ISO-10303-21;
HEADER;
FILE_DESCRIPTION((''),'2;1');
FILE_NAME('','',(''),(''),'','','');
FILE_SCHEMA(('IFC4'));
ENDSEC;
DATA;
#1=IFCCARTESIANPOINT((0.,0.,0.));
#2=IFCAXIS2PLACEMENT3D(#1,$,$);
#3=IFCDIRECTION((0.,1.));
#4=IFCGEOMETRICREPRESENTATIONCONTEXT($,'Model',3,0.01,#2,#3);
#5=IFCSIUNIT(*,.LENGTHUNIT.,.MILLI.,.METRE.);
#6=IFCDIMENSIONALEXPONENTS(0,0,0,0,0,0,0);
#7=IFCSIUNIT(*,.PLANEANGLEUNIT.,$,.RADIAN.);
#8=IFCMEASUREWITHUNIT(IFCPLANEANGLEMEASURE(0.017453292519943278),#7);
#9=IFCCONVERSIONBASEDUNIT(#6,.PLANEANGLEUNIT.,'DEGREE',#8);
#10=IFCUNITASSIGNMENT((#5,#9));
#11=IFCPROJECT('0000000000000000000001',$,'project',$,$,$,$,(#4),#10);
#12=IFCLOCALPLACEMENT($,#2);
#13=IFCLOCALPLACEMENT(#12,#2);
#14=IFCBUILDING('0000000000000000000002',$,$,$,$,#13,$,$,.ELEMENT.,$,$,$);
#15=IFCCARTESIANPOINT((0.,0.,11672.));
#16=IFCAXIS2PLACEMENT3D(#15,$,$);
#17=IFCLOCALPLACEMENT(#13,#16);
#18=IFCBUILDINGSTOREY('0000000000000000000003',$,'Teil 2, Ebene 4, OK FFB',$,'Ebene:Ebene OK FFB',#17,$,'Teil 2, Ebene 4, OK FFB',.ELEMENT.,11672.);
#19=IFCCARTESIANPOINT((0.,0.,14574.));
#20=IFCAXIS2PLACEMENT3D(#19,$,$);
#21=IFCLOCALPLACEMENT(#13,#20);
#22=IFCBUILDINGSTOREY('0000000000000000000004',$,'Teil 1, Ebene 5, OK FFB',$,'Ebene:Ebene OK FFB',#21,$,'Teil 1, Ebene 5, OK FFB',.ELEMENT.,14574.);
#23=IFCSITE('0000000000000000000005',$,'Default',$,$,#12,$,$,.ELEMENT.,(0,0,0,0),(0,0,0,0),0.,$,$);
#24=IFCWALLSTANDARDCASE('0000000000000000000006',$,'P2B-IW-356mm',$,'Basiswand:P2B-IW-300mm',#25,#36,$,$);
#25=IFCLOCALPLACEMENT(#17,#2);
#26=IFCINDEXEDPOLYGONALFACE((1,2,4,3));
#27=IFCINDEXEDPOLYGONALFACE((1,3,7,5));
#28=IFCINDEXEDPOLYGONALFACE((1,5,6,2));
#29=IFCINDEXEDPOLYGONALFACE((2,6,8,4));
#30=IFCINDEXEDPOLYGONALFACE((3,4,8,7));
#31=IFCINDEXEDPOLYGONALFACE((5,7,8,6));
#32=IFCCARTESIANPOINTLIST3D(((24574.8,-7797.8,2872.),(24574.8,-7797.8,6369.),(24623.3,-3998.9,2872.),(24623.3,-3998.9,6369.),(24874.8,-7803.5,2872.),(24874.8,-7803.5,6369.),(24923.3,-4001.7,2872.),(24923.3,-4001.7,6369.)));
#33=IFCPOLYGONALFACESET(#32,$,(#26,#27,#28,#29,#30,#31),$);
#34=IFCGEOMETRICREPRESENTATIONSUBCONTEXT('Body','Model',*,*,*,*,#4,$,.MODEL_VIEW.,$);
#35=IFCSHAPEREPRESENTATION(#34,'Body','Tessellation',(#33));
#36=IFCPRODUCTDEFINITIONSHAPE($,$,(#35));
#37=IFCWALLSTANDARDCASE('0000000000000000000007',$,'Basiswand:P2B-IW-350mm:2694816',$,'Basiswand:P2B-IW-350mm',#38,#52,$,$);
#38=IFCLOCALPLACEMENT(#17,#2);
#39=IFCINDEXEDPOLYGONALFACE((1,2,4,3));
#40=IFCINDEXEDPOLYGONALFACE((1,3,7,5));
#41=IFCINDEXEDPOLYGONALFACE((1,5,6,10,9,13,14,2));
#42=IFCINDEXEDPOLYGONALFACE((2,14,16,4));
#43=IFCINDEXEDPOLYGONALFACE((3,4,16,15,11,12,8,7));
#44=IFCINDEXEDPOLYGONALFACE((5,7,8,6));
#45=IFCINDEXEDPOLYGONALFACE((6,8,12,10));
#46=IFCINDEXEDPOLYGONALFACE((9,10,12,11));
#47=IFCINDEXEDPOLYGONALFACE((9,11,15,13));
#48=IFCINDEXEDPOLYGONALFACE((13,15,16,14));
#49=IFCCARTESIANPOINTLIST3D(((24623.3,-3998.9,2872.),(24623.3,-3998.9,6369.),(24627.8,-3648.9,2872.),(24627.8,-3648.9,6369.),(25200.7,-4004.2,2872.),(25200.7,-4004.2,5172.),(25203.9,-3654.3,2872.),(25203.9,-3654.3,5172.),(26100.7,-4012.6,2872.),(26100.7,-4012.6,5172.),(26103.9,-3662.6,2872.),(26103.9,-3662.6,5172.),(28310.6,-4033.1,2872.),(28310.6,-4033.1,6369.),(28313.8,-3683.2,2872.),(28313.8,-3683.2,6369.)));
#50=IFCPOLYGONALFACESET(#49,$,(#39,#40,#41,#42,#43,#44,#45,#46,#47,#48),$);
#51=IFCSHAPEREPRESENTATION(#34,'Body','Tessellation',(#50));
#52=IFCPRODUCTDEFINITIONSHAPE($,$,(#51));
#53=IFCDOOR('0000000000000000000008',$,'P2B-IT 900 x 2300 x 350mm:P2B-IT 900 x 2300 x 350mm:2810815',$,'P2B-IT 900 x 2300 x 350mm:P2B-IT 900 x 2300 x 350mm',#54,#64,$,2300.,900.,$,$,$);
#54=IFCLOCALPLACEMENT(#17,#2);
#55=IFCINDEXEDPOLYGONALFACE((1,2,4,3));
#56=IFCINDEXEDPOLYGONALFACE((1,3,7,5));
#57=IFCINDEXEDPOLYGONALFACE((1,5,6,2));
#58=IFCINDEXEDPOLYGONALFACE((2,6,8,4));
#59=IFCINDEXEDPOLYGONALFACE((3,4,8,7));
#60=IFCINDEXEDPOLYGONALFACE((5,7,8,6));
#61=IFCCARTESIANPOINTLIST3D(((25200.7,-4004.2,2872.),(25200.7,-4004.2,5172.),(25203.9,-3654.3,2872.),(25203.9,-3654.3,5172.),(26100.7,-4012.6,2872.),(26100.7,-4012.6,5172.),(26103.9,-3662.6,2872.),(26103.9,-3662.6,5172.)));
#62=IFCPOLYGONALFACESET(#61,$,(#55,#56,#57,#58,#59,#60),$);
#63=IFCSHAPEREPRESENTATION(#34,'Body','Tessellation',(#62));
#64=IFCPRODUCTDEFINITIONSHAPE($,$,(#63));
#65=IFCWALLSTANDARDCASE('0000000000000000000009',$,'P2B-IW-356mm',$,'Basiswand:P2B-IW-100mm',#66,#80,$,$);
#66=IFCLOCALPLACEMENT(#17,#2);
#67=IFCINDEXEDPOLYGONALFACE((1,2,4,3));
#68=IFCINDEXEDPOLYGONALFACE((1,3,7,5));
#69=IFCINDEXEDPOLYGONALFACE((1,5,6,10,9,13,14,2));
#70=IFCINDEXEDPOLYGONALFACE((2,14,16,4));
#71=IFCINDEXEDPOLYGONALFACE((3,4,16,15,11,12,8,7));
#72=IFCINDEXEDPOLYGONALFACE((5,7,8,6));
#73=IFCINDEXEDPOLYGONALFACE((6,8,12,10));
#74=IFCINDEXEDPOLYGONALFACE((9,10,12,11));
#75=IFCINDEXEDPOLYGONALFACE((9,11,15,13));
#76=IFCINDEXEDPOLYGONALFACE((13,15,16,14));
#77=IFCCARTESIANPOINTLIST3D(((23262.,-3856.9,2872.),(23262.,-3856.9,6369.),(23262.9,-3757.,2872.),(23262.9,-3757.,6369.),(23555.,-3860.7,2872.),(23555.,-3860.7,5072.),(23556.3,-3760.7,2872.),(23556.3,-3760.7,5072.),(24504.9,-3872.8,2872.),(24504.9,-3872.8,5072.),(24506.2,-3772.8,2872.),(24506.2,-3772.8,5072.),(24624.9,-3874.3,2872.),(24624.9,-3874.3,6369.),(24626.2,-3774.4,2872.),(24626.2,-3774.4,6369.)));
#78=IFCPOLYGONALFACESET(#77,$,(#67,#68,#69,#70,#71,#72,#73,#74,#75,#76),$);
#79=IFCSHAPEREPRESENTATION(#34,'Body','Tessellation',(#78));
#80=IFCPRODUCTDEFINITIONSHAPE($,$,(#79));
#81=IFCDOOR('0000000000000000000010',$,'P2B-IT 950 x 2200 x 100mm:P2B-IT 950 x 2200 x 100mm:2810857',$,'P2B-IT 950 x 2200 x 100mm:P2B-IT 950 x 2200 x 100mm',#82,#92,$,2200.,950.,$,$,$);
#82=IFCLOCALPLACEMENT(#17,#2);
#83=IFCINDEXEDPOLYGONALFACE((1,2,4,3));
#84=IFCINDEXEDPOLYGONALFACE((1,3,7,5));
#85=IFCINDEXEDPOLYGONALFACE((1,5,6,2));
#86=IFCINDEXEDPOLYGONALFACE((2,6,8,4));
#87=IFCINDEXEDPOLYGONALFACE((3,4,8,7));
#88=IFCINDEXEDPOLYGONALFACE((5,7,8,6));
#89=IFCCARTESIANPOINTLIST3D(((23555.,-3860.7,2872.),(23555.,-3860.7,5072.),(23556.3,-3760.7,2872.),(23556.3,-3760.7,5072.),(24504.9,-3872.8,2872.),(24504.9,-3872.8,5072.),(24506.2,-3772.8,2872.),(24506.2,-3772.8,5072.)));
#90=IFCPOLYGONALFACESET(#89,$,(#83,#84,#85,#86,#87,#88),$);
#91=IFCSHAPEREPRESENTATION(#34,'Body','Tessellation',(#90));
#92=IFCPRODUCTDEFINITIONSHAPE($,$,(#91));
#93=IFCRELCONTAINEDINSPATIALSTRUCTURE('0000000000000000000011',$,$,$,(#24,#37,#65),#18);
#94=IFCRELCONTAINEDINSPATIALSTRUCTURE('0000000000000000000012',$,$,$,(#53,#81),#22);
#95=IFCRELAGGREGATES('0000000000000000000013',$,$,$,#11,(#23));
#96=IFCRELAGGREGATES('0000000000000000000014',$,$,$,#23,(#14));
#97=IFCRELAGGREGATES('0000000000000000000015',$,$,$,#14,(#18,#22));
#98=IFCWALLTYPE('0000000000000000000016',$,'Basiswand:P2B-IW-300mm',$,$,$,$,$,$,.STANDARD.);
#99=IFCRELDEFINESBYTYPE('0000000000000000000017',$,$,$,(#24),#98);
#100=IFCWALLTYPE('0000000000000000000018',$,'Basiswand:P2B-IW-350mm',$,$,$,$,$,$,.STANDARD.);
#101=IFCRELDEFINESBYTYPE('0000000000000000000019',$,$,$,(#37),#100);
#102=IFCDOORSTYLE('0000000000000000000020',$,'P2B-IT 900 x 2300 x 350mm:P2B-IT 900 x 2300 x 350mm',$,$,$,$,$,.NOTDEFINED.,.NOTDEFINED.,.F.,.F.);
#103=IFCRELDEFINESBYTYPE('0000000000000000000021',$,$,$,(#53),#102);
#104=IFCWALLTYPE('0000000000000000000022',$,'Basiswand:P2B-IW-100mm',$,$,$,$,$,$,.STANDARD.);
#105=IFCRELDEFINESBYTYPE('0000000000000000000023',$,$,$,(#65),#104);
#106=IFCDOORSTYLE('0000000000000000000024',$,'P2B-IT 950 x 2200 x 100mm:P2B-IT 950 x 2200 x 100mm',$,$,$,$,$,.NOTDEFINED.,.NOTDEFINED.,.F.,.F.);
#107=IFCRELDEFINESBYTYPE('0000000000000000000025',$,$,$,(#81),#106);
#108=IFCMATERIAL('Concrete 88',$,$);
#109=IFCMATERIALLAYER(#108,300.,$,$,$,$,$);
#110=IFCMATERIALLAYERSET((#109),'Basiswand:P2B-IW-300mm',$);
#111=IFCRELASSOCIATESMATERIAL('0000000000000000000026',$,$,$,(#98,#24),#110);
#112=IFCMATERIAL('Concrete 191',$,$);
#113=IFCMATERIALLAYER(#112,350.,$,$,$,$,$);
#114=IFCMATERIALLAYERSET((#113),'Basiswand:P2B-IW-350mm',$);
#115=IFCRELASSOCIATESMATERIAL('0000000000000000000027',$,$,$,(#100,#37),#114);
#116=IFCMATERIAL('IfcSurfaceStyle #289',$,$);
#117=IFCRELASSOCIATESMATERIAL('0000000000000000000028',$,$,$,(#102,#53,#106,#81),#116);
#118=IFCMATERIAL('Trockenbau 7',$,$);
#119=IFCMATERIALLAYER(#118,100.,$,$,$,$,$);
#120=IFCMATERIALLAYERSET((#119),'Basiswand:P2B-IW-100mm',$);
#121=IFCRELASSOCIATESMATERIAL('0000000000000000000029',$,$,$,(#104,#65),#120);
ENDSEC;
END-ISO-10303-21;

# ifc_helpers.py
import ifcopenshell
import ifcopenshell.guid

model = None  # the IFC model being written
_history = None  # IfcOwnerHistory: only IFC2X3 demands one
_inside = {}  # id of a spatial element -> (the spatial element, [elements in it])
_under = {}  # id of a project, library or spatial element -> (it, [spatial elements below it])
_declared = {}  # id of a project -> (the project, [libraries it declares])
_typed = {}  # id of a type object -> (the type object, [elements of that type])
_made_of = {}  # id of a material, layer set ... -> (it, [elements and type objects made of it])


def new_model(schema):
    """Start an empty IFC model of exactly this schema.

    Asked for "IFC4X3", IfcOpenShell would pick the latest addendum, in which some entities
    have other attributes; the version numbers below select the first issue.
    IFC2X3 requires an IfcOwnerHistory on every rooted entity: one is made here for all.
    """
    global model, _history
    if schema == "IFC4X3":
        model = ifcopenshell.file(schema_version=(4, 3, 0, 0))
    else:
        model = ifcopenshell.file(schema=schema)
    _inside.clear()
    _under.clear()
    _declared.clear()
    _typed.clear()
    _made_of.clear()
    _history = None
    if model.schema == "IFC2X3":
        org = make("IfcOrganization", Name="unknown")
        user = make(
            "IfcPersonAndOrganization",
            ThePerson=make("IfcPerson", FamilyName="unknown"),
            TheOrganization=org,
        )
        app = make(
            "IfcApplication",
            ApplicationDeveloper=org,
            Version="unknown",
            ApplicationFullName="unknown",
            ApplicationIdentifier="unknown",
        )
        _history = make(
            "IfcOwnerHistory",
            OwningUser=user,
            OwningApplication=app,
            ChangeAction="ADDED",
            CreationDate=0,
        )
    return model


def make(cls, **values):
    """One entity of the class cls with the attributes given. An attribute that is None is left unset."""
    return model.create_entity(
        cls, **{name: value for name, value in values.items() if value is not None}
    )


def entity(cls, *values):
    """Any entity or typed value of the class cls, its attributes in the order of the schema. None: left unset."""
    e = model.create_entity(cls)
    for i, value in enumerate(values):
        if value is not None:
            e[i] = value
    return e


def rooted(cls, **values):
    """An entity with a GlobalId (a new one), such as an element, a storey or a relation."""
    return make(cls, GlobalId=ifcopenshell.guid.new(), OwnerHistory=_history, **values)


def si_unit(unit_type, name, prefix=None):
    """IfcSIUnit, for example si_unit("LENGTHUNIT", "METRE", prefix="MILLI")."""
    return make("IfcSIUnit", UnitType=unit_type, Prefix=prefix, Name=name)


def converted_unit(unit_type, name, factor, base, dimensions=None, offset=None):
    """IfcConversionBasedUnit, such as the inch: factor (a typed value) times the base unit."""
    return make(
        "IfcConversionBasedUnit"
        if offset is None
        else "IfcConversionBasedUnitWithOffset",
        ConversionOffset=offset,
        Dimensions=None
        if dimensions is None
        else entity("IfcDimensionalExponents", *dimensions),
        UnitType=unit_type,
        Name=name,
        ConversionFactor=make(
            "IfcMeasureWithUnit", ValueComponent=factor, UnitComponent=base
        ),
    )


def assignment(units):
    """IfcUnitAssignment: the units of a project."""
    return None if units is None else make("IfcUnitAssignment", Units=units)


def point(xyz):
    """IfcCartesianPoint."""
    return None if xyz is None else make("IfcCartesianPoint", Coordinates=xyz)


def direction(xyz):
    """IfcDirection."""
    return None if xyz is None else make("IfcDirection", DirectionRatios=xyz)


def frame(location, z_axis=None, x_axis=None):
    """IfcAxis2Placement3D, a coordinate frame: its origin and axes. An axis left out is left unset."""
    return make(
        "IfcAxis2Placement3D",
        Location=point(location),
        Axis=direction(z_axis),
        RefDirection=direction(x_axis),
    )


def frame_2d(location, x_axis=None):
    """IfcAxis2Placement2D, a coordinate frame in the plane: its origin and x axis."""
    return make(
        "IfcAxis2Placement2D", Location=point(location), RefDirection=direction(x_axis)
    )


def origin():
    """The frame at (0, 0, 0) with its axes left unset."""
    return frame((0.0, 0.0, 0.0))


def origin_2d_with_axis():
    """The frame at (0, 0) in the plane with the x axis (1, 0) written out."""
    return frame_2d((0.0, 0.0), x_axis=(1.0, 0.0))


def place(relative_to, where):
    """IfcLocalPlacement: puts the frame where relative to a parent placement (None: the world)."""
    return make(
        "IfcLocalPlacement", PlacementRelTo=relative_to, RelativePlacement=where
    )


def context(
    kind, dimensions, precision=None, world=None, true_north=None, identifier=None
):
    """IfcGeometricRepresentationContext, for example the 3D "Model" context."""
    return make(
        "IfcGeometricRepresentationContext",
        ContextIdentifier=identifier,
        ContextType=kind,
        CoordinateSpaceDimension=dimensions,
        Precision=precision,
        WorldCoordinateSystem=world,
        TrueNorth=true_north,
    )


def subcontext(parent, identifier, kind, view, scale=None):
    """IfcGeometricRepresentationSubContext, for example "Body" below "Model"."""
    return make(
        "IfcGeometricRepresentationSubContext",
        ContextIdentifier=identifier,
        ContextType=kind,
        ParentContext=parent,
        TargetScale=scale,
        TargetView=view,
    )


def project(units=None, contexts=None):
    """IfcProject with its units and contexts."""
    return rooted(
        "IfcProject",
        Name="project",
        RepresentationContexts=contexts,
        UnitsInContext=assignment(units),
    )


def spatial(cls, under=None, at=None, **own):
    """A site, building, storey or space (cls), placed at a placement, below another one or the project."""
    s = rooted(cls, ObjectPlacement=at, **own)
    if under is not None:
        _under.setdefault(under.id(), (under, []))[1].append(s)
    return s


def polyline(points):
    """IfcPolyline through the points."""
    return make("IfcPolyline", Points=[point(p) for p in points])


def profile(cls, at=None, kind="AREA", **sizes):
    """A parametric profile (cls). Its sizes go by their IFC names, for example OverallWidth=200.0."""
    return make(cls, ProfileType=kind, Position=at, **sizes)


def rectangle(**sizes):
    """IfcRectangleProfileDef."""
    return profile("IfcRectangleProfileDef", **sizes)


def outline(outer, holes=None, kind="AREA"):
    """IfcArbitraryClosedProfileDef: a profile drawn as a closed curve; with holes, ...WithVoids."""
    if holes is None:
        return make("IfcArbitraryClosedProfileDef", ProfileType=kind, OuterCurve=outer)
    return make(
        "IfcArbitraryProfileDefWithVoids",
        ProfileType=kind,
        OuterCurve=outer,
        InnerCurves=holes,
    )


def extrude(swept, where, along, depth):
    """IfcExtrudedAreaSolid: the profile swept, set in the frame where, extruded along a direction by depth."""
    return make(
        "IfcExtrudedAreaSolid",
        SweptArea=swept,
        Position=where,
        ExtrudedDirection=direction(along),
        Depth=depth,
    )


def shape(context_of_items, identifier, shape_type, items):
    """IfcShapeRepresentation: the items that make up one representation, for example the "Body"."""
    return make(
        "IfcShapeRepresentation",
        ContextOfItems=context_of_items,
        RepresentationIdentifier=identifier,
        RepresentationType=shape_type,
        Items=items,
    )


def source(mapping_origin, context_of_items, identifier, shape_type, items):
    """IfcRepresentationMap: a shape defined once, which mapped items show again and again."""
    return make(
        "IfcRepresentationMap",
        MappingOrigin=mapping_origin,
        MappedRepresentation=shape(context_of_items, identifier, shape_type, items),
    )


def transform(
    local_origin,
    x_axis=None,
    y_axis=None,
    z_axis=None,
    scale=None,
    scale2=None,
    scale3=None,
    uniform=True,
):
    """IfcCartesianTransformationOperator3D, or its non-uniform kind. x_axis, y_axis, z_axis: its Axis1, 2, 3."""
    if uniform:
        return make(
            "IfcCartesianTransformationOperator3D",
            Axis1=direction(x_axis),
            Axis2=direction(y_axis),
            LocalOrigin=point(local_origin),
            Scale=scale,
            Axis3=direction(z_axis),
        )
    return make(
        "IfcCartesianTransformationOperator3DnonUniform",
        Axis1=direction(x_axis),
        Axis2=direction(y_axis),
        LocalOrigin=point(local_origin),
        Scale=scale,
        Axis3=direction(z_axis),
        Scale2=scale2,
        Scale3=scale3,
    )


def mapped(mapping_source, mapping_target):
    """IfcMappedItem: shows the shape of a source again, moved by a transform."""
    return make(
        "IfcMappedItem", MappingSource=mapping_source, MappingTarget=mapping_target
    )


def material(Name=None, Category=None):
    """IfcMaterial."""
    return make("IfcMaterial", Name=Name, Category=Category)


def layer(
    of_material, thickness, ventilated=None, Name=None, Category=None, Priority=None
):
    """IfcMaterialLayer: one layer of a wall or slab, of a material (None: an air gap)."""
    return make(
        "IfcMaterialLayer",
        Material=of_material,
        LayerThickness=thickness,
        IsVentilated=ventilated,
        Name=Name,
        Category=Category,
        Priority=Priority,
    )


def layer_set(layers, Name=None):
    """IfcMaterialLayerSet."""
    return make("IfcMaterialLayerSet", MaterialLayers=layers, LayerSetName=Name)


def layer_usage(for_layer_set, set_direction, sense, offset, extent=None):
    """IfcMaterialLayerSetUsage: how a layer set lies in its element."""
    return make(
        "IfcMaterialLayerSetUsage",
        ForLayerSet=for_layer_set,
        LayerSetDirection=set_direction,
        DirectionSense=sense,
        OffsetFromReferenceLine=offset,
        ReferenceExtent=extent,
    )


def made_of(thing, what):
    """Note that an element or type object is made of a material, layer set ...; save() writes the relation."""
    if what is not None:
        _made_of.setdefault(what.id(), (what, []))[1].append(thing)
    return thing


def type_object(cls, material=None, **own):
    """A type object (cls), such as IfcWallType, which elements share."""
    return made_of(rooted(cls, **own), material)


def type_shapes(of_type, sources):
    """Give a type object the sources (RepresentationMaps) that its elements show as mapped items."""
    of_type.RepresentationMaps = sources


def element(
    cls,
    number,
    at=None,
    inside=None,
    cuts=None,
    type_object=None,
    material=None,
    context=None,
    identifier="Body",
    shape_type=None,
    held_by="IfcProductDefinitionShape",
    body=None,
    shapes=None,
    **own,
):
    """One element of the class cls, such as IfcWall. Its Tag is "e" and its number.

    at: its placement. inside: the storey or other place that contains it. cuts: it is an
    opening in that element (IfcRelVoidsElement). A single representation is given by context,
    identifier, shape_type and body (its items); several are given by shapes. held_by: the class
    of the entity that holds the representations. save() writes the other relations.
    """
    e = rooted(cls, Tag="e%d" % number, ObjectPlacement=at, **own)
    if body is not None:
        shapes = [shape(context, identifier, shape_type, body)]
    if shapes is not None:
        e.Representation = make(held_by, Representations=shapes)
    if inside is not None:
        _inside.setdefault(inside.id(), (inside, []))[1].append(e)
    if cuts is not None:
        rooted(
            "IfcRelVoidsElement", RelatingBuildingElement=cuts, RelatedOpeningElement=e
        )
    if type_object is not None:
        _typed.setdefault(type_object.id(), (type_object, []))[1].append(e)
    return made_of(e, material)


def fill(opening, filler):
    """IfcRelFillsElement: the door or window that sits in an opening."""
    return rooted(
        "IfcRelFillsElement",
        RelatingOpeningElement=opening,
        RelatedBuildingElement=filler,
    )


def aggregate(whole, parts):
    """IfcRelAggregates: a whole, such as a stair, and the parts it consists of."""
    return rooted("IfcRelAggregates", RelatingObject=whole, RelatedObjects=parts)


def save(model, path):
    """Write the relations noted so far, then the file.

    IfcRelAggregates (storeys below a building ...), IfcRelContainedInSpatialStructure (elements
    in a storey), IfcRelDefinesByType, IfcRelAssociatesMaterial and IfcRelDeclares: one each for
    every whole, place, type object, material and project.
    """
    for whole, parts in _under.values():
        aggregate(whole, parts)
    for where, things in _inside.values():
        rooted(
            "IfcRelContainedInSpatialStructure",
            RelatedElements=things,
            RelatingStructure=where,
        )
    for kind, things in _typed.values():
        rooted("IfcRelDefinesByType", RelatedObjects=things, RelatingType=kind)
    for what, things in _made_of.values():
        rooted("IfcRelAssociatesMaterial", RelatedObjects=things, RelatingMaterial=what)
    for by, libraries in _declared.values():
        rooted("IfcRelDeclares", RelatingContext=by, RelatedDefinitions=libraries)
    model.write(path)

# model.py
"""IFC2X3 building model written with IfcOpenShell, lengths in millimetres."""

from ifc_helpers import new_model, entity, si_unit, converted_unit, direction, frame, frame_2d, origin, origin_2d_with_axis, place, context, subcontext, project, spatial, polyline, rectangle, outline, extrude, source, transform, mapped, material, layer, layer_set, layer_usage, type_object, type_shapes, element, fill, save


model = new_model("IFC2X3")

# Units and contexts
model_context = context("Model", 3, precision=0.01, world=origin(), true_north=direction((0.0, 1.0)))
body_context = subcontext(model_context, "Body", "Model", "MODEL_VIEW")
ifc_project = project(units=[si_unit("LENGTHUNIT", "METRE", prefix="MILLI"), converted_unit("PLANEANGLEUNIT", "DEGREE", entity("IfcPlaneAngleMeasure", 0.017453292519943278), si_unit("PLANEANGLEUNIT", "RADIAN"), dimensions=[0, 0, 0, 0, 0, 0, 0])], contexts=[model_context])

# Site, building, storey
site_placement = place(None, origin())
site = spatial("IfcSite", under=ifc_project, at=site_placement, Name="Default", CompositionType="ELEMENT", RefLatitude=(0, 0, 0, 0), RefLongitude=(0, 0, 0, 0), RefElevation=0.0)
building_placement = place(site_placement, origin())
building = spatial("IfcBuilding", under=site, at=building_placement, CompositionType="ELEMENT")
storey_1_placement = place(building_placement, frame((0.0, 0.0, 11672.0)))
storey_1 = spatial("IfcBuildingStorey", under=building, at=storey_1_placement, Name="Teil 2, Ebene 4, OK FFB", ObjectType="Ebene:Ebene OK FFB", LongName="Teil 2, Ebene 4, OK FFB", CompositionType="ELEMENT", Elevation=11672.0)

# Wall
ifc_material_1 = material(Name="Concrete 88")
ifc_layer_1 = layer(ifc_material_1, 300.0)
ifc_layer_set_1 = layer_set([ifc_layer_1], Name="Basiswand:P2B-IW-300mm")
ifc_layer_usage_1 = layer_usage(ifc_layer_set_1, "AXIS2", "NEGATIVE", 150.0)
wall_type_1 = type_object("IfcWallType", Name="Basiswand:P2B-IW-300mm", PredefinedType="STANDARD", material=ifc_layer_set_1)
wall_1_placement = place(storey_1_placement, frame((24773.3, -3999.8, 2872.0), z_axis=(0.0, 0.0, 1.0), x_axis=(-0.012765, -0.999919, 0.0)))
element("IfcWallStandardCase", 1, at=wall_1_placement, inside=storey_1, type_object=wall_type_1, material=ifc_layer_usage_1, Name="P2B-IW-356mm", ObjectType="Basiswand:P2B-IW-300mm", context=body_context, shape_type="SweptSolid", body=[
    extrude(outline(polyline([(3800.2, -150.0), (3802.1, 150.0), (0.0, 150.0), (1.0, -150.0), (3800.2, -150.0)])), origin(), (0.0, 0.0, 1.0), 3497.0),
])

# Wall, opening
ifc_material_2 = material(Name="Concrete 191")
ifc_layer_2 = layer(ifc_material_2, 350.0)
ifc_layer_set_2 = layer_set([ifc_layer_2], Name="Basiswand:P2B-IW-350mm")
ifc_layer_usage_2 = layer_usage(ifc_layer_set_2, "AXIS2", "POSITIVE", -175.0)
wall_type_2 = type_object("IfcWallType", Name="Basiswand:P2B-IW-350mm", PredefinedType="STANDARD", material=ifc_layer_set_2)
wall_2_placement = place(storey_1_placement, frame((24624.9, -3823.9, 2872.0), z_axis=(0.0, 0.0, 1.0), x_axis=(0.999957, -0.00929, 0.0)))
wall_2 = element("IfcWallStandardCase", 2, at=wall_2_placement, inside=storey_1, type_object=wall_type_2, material=ifc_layer_usage_2, Name="Basiswand:P2B-IW-350mm:2694816", ObjectType="Basiswand:P2B-IW-350mm", context=body_context, shape_type="SweptSolid", body=[
    extrude(outline(polyline([(0.0, -175.0), (300.0, -175.0), (3687.4, -175.0), (3687.4, 175.0), (1.2, 175.0), (0.8, 49.5), (0.4, -50.5), (0.0, -175.0)])), origin(), (0.0, 0.0, 1.0), 3497.0),
])
opening_1_placement = place(wall_2_placement, frame((-24659.4, 3594.9, 30.0), z_axis=(0.0, 0.0, 1.0), x_axis=(0.999957, 0.00929, 0.0)))
opening_1 = element("IfcOpeningElement", 3, at=opening_1_placement, cuts=wall_2, ObjectType="Opening", context=body_context, shape_type="SweptSolid", body=[
    extrude(rectangle(XDim=2300.0, YDim=900.0, at=frame_2d((0.0, 0.0), x_axis=(1.0, 0.0))), frame((25650.7, -4008.4, 1120.0), z_axis=(0.00929, 0.999957, 0.0), x_axis=(0.0, 0.0, -1.0)), (0.0, 0.0, 1.0), 350.0),
])

# Shared definitions
storey_2_placement = place(building_placement, frame((0.0, 0.0, 14574.0)))
storey_2 = spatial("IfcBuildingStorey", under=building, at=storey_2_placement, Name="Teil 1, Ebene 5, OK FFB", ObjectType="Ebene:Ebene OK FFB", LongName="Teil 1, Ebene 5, OK FFB", CompositionType="ELEMENT", Elevation=14574.0)

# Door
ifc_material_3 = material(Name="IfcSurfaceStyle #289")
door_style_1 = type_object("IfcDoorStyle", Name="P2B-IT 900 x 2300 x 350mm:P2B-IT 900 x 2300 x 350mm", ConstructionType="NOTDEFINED", OperationType="NOTDEFINED", ParameterTakesPrecedence=False, Sizeable=False, material=ifc_material_3)
shared_shape_1 = source(origin(), body_context, "Body", "SweptSolid", [
    extrude(rectangle(XDim=350.0, YDim=900.0, at=origin_2d_with_axis()), frame((450.0, -175.0, 0.0), z_axis=(0.0, 0.0, 1.0), x_axis=(0.0, 1.0, 0.0)), (0.0, 0.0, 1.0), 2300.0),
])
type_shapes(door_style_1, [shared_shape_1])
door_1_placement = place(opening_1_placement, frame((25203.9, -3654.3, -30.0), z_axis=(0.0, 0.0, 1.0), x_axis=(0.999957, -0.00929, 0.0)))
door_1 = element("IfcDoor", 4, at=door_1_placement, inside=storey_2, type_object=door_style_1, material=ifc_material_3, Name="P2B-IT 900 x 2300 x 350mm:P2B-IT 900 x 2300 x 350mm:2810815", ObjectType="P2B-IT 900 x 2300 x 350mm:P2B-IT 900 x 2300 x 350mm", OverallHeight=2300.0, OverallWidth=900.0, context=body_context, shape_type="MappedRepresentation", body=[
    mapped(shared_shape_1, transform((0.0, 0.0, 0.0), scale=1.0)),
])
fill(opening_1, door_1)

# Wall, opening, door
ifc_material_4 = material(Name="Trockenbau 7")
ifc_layer_3 = layer(ifc_material_4, 100.0)
ifc_layer_set_3 = layer_set([ifc_layer_3], Name="Basiswand:P2B-IW-100mm")
ifc_layer_usage_3 = layer_usage(ifc_layer_set_3, "AXIS2", "POSITIVE", -50.0)
wall_type_3 = type_object("IfcWallType", Name="Basiswand:P2B-IW-100mm", PredefinedType="STANDARD", material=ifc_layer_set_3)
wall_3_placement = place(storey_1_placement, frame((23262.3, -3806.9, 2872.0), z_axis=(0.0, 0.0, 1.0), x_axis=(0.999919, -0.012765, 0.0)))
wall_3 = element("IfcWallStandardCase", 5, at=wall_3_placement, inside=storey_1, type_object=wall_type_3, material=ifc_layer_usage_3, Name="P2B-IW-356mm", ObjectType="Basiswand:P2B-IW-100mm", context=body_context, shape_type="SweptSolid", body=[
    extrude(outline(polyline([(0.3, -50.0), (1363.4, -50.0), (1363.4, 50.0), (100.0, 50.0), (0.0, 50.0), (0.1, 18.9), (0.3, -50.0)])), origin(), (0.0, 0.0, 1.0), 3497.0),
])
opening_2_placement = place(wall_3_placement, frame((-23309.0, 3509.7, 30.0), z_axis=(0.0, 0.0, 1.0), x_axis=(0.999919, 0.012765, 0.0)))
opening_2 = element("IfcOpeningElement", 6, at=opening_2_placement, cuts=wall_3, ObjectType="Opening", context=body_context, shape_type="SweptSolid", body=[
    extrude(rectangle(XDim=2200.0, YDim=950.0, at=frame_2d((0.0, 0.0), x_axis=(1.0, 0.0))), frame((24028.7, -3966.7, 1070.0), z_axis=(0.012765, 0.999919, 0.0), x_axis=(0.0, 0.0, -1.0)), (0.0, 0.0, 1.0), 300.0),
])
door_style_2 = type_object("IfcDoorStyle", Name="P2B-IT 950 x 2200 x 100mm:P2B-IT 950 x 2200 x 100mm", ConstructionType="NOTDEFINED", OperationType="NOTDEFINED", ParameterTakesPrecedence=False, Sizeable=False, material=ifc_material_3)
shared_shape_2 = source(origin(), body_context, "Body", "SweptSolid", [
    extrude(rectangle(XDim=100.0, YDim=950.0, at=frame_2d((0.0, 0.0), x_axis=(1.0, 0.0))), frame((475.0, 150.0, 0.0), z_axis=(0.0, 0.0, 1.0), x_axis=(0.0, 1.0, 0.0)), (0.0, 0.0, 1.0), 2200.0),
])
type_shapes(door_style_2, [shared_shape_2])
door_2_placement = place(opening_2_placement, frame((24507.5, -3672.8, -30.0), z_axis=(0.0, 0.0, 1.0), x_axis=(-0.999919, 0.012765, 0.0)))
door_2 = element("IfcDoor", 7, at=door_2_placement, inside=storey_2, type_object=door_style_2, material=ifc_material_3, Name="P2B-IT 950 x 2200 x 100mm:P2B-IT 950 x 2200 x 100mm:2810857", ObjectType="P2B-IT 950 x 2200 x 100mm:P2B-IT 950 x 2200 x 100mm", OverallHeight=2200.0, OverallWidth=950.0, context=body_context, shape_type="MappedRepresentation", body=[
    mapped(shared_shape_2, transform((0.0, 0.0, 0.0), scale=1.0)),
])
fill(opening_2, door_2)

save(model, "model.ifc")
